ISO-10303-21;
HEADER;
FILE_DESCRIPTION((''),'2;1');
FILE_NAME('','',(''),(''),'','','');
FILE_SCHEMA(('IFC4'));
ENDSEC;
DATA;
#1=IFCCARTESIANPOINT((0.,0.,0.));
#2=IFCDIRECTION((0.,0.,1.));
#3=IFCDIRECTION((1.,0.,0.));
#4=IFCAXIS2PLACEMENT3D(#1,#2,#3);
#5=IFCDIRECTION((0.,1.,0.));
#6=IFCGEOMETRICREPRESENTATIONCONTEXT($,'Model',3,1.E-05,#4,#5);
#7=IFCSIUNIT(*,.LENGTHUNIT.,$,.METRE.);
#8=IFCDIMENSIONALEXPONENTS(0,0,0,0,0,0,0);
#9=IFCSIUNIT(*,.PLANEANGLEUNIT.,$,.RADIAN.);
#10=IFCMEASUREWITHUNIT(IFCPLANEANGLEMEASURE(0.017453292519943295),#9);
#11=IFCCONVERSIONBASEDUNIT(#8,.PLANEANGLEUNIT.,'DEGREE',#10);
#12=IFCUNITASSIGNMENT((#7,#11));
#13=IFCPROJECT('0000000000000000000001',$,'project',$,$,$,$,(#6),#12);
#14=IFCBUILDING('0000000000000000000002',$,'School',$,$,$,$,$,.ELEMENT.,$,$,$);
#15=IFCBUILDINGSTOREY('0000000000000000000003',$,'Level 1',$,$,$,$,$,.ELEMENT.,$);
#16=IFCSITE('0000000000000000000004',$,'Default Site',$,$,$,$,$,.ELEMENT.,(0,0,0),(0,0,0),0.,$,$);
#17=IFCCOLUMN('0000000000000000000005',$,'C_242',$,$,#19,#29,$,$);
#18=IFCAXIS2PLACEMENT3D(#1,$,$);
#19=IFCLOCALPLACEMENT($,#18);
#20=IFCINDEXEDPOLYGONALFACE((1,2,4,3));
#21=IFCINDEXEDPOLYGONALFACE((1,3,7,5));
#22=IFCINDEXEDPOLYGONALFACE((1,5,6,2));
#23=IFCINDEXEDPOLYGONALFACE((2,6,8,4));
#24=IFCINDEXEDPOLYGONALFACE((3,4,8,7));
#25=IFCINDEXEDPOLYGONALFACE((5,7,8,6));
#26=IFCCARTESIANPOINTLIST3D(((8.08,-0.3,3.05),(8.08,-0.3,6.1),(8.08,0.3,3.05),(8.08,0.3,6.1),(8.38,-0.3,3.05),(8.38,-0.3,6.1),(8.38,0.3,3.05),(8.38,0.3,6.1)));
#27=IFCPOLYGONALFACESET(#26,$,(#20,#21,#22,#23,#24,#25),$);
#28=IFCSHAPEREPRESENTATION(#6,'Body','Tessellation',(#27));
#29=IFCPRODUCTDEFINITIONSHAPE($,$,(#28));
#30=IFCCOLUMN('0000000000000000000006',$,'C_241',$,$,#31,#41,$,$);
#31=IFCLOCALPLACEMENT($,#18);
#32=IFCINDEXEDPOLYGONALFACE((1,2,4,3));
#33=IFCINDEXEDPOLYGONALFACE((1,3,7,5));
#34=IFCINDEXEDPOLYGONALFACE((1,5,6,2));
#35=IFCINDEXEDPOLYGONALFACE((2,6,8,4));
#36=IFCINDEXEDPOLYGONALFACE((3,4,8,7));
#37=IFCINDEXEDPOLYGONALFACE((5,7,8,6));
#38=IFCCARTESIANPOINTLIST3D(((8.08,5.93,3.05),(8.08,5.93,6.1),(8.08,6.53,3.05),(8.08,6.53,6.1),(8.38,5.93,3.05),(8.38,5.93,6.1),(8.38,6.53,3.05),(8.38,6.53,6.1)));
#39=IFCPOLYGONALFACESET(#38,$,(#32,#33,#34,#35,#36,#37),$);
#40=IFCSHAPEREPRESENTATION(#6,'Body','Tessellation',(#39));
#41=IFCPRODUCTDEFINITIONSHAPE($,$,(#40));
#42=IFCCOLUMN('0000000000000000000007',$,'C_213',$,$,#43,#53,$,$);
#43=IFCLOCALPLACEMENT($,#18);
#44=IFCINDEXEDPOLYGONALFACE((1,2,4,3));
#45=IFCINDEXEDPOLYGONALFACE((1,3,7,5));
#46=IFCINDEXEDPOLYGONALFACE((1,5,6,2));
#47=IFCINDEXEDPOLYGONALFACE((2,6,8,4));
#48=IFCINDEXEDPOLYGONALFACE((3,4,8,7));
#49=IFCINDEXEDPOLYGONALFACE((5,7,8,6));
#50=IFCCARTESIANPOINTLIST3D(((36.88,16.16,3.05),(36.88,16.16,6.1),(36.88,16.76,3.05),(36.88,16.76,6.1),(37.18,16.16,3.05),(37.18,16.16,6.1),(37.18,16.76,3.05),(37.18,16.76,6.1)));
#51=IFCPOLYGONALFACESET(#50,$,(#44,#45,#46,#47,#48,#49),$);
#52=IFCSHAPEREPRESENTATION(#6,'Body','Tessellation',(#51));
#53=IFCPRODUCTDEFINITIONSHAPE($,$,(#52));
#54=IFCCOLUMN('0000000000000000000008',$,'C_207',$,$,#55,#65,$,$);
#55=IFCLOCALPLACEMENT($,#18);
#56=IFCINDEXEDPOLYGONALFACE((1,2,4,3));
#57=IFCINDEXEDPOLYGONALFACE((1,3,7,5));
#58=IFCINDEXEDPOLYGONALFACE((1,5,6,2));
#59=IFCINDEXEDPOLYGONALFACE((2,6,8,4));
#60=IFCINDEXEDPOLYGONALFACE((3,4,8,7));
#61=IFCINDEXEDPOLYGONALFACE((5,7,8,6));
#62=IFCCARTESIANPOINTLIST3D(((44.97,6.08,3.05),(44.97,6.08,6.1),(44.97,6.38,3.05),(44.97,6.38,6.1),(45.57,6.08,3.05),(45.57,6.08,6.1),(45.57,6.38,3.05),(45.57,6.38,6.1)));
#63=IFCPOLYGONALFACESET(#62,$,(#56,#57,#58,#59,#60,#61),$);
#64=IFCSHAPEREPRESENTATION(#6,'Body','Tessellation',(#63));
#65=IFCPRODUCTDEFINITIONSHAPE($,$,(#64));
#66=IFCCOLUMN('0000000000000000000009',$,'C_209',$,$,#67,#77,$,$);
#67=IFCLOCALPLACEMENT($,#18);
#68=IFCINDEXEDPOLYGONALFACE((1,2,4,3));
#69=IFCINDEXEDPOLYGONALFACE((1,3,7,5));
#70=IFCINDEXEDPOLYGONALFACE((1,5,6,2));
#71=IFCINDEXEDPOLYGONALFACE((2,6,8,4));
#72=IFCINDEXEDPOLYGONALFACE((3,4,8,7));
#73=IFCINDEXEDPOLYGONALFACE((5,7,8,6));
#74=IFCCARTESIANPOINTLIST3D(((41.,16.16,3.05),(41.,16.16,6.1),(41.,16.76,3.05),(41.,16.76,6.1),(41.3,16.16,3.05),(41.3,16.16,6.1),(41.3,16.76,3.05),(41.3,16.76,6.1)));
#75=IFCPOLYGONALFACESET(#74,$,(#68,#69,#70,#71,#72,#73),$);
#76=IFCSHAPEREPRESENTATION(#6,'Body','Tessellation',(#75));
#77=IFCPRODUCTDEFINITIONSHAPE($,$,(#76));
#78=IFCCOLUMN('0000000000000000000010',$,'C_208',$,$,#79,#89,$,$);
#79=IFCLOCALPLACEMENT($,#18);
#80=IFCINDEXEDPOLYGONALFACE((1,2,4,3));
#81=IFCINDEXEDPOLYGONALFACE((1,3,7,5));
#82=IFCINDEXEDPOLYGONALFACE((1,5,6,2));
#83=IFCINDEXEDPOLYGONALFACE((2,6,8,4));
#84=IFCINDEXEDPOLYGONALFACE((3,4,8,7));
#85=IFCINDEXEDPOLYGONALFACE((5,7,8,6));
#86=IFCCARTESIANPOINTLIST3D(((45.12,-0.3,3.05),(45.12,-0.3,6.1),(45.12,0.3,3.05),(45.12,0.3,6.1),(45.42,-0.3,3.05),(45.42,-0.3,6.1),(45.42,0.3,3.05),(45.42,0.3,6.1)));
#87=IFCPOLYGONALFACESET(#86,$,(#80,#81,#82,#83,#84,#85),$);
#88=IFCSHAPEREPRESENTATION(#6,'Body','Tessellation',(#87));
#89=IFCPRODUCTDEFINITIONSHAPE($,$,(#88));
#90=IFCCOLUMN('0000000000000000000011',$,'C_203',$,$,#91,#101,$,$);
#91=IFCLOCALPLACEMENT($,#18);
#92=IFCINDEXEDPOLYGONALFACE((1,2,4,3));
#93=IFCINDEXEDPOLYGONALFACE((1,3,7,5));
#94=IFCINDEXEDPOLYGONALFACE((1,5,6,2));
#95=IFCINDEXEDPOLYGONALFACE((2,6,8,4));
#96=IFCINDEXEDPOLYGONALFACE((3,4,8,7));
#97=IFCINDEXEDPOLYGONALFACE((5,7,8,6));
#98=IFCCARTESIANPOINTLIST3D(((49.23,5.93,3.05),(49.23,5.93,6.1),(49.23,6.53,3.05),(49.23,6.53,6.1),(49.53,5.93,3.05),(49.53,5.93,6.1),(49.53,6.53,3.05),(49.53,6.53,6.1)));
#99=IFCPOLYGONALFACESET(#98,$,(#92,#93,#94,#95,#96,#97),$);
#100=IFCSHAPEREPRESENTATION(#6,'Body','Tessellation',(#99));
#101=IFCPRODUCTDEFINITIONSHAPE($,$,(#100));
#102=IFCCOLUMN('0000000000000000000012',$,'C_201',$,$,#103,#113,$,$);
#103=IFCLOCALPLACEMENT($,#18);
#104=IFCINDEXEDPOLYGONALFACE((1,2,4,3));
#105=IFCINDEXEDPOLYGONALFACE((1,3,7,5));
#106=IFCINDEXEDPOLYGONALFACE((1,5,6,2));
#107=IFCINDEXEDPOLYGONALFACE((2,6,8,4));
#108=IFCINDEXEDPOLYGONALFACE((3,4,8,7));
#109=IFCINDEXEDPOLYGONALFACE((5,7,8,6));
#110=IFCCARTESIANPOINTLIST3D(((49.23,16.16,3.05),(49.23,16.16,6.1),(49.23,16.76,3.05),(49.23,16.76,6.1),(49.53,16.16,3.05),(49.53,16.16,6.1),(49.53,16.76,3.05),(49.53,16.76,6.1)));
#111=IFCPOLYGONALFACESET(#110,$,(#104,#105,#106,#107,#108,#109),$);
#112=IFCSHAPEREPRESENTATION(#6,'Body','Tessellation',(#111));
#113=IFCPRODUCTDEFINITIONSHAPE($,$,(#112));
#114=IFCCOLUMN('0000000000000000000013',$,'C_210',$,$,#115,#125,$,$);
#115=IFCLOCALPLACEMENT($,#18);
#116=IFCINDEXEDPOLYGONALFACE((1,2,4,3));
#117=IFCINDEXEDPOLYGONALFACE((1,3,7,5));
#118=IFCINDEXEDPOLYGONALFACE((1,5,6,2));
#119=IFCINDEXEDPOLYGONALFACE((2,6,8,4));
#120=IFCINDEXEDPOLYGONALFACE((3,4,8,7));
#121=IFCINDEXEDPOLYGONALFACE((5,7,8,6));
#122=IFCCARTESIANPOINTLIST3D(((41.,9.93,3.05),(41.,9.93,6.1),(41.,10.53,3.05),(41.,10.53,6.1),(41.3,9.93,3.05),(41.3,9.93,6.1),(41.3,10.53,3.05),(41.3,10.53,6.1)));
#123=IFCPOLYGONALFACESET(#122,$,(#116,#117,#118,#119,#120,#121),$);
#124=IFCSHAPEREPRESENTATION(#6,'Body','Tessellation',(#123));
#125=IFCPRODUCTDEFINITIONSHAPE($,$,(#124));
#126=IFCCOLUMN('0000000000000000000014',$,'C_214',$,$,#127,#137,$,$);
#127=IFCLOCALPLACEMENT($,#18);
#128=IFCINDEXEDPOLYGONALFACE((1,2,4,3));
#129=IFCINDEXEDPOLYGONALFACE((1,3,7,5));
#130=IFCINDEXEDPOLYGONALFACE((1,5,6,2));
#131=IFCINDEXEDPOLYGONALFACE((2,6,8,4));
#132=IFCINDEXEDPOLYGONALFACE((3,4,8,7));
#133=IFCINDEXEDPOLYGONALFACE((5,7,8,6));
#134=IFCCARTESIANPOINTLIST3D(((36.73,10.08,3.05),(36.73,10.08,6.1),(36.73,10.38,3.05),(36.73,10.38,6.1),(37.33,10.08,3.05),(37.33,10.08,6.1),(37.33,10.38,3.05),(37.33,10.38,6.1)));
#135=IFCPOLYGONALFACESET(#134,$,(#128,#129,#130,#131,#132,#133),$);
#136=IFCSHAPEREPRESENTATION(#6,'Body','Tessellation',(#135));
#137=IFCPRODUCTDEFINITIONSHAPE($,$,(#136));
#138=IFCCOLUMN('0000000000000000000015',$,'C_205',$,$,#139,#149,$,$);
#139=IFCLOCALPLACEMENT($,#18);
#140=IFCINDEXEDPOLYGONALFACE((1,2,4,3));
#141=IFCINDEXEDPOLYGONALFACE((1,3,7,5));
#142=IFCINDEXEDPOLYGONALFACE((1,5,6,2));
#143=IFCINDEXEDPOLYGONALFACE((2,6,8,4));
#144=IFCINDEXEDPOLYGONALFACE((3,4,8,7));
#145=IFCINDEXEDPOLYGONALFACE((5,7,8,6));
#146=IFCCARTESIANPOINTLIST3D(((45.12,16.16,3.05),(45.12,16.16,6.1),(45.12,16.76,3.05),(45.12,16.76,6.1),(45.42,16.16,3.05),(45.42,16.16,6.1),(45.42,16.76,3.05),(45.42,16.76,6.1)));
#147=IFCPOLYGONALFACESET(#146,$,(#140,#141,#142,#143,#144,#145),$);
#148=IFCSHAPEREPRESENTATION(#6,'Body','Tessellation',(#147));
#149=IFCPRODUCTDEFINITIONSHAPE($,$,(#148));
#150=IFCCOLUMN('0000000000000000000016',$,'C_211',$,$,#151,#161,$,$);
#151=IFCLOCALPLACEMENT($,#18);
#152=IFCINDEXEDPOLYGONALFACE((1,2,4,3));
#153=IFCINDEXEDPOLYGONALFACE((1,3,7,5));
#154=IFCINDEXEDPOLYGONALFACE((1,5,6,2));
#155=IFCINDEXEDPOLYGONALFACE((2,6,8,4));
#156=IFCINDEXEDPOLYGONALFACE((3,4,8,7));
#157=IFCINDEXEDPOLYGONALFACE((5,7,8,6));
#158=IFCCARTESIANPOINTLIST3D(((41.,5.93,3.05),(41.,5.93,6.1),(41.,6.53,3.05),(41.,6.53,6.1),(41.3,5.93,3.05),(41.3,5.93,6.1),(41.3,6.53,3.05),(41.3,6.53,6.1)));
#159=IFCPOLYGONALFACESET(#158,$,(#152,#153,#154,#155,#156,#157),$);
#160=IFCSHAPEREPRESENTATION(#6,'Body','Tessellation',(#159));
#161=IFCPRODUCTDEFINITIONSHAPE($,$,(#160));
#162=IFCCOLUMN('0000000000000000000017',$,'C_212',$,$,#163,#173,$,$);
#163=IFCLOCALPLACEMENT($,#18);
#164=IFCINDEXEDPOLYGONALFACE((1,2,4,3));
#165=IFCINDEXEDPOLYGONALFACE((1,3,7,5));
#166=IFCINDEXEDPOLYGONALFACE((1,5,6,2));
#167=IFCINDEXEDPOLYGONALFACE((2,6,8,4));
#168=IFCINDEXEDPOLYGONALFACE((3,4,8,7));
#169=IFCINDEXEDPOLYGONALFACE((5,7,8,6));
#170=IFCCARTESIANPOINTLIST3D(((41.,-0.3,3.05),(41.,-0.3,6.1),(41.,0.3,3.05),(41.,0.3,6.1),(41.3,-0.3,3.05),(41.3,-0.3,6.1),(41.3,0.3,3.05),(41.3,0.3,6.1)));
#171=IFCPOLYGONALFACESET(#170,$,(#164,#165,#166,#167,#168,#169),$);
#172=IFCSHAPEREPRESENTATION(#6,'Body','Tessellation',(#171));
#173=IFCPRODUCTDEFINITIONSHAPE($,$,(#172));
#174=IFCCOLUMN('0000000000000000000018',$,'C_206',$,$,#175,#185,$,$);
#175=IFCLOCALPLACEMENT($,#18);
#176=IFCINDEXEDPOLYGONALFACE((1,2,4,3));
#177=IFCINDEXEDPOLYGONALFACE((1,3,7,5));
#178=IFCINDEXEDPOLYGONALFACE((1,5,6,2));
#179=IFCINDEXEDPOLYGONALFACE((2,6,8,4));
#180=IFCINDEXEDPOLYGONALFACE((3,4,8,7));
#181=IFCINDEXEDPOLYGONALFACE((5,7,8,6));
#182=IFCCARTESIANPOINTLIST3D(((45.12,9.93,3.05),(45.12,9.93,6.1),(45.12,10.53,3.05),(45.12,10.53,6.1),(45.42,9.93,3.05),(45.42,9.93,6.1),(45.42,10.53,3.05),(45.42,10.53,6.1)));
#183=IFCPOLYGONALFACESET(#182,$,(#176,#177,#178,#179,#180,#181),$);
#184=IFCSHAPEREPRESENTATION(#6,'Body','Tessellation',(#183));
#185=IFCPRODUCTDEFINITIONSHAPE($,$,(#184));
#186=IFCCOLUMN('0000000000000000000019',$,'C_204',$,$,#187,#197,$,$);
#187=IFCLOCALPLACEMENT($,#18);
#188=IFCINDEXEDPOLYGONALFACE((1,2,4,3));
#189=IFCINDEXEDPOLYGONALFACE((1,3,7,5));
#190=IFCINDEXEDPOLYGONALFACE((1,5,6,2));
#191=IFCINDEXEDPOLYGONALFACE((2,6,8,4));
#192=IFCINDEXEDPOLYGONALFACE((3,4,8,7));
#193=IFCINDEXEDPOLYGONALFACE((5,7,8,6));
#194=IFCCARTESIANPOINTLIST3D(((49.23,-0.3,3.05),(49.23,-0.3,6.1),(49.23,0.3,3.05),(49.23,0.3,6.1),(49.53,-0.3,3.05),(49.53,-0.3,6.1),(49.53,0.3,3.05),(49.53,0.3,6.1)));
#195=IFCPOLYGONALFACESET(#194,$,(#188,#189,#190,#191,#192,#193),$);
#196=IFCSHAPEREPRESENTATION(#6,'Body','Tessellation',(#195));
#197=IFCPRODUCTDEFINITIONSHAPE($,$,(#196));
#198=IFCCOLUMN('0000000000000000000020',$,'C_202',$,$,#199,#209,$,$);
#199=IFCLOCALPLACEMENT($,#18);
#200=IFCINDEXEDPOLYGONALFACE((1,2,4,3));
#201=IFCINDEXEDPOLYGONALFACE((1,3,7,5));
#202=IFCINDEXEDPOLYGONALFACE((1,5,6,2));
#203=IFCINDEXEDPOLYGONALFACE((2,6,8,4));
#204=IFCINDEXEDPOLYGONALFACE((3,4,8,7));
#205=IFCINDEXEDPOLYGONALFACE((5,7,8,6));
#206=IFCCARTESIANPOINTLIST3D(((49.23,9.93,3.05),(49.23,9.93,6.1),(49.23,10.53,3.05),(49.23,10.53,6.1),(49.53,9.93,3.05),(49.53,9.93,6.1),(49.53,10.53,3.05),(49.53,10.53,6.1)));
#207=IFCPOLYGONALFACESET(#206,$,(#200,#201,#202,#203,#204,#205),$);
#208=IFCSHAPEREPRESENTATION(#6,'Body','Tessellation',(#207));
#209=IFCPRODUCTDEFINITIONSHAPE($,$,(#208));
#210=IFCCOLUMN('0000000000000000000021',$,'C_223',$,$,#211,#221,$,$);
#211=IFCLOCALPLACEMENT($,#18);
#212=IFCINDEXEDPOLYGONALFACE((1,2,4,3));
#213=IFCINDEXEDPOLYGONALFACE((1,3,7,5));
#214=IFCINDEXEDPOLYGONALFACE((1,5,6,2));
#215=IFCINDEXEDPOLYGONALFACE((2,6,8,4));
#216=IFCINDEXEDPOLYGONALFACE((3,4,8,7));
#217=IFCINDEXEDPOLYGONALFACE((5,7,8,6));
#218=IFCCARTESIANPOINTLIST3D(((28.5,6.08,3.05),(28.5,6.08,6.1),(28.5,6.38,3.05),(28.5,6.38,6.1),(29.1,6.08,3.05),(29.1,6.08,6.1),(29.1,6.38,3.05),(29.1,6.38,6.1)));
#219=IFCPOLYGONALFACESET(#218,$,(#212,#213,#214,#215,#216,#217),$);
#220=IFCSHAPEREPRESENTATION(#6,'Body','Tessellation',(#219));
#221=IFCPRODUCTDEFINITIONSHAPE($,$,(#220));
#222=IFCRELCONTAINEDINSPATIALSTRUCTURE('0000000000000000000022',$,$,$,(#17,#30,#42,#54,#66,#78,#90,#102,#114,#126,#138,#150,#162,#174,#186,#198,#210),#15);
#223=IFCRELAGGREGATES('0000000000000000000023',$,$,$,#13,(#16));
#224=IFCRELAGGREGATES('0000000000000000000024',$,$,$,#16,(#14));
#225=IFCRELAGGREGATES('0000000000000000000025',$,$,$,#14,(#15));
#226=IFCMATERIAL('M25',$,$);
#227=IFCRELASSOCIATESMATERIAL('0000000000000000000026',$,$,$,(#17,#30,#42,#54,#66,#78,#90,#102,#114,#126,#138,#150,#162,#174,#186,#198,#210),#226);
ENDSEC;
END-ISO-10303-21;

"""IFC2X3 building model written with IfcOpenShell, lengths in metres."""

from ifc_helpers import new_model, entity, si_unit, converted_unit, direction, frame, frame_2d, origin_with_axes, place, context, project, spatial, rectangle, extrude, material, element, save


model = new_model("IFC2X3")

# Units and contexts
model_context = context("Model", 3, precision=1e-05, world=origin_with_axes(), true_north=direction((0.0, 1.0, 0.0)))
ifc_project = project(units=[si_unit("LENGTHUNIT", "METRE"), converted_unit("PLANEANGLEUNIT", "DEGREE", entity("IfcPlaneAngleMeasure", 0.017453292519943295), si_unit("PLANEANGLEUNIT", "RADIAN"), dimensions=[0, 0, 0, 0, 0, 0, 0])], contexts=[model_context])

# Site, building, storey
site = spatial("IfcSite", under=ifc_project, Name="Default Site", CompositionType="ELEMENT", RefLatitude=(0, 0, 0), RefLongitude=(0, 0, 0), RefElevation=0.0)
building = spatial("IfcBuilding", under=site, Name="School", CompositionType="ELEMENT")
storey = spatial("IfcBuildingStorey", under=building, Name="Level 1", CompositionType="ELEMENT")

# Columns
ifc_material = material(Name="M25")
placement = place(None, origin_with_axes())
element("IfcColumn", 1, at=placement, inside=storey, material=ifc_material, Name="C_242", context=model_context, shape_type="SweptSolid", body=[
    extrude(rectangle(XDim=0.3, YDim=0.6, at=frame_2d((0.0, 0.0), x_axis=(1.0, 0.0, 0.0))), frame((8.23, 0.0, 3.05), z_axis=(0.0, 0.0, 1.0), x_axis=(1.0, 0.0, 0.0)), (0.0, 0.0, 1.0), 3.05),
])
element("IfcColumn", 2, at=placement, inside=storey, material=ifc_material, Name="C_241", context=model_context, shape_type="SweptSolid", body=[
    extrude(rectangle(XDim=0.3, YDim=0.6, at=frame_2d((0.0, 0.0), x_axis=(1.0, 0.0, 0.0))), frame((8.23, 6.23, 3.05), z_axis=(0.0, 0.0, 1.0), x_axis=(1.0, 0.0, 0.0)), (0.0, 0.0, 1.0), 3.05),
])
element("IfcColumn", 3, at=placement, inside=storey, material=ifc_material, Name="C_213", context=model_context, shape_type="SweptSolid", body=[
    extrude(rectangle(XDim=0.3, YDim=0.6, at=frame_2d((0.0, 0.0), x_axis=(1.0, 0.0, 0.0))), frame((37.03, 16.46, 3.05), z_axis=(0.0, 0.0, 1.0), x_axis=(1.0, 0.0, 0.0)), (0.0, 0.0, 1.0), 3.05),
])
element("IfcColumn", 4, at=placement, inside=storey, material=ifc_material, Name="C_207", context=model_context, shape_type="SweptSolid", body=[
    extrude(rectangle(XDim=0.6, YDim=0.3, at=frame_2d((0.0, 0.0), x_axis=(1.0, 0.0, 0.0))), frame((45.27, 6.23, 3.05), z_axis=(0.0, 0.0, 1.0), x_axis=(1.0, 0.0, 0.0)), (0.0, 0.0, 1.0), 3.05),
])
element("IfcColumn", 5, at=placement, inside=storey, material=ifc_material, Name="C_209", context=model_context, shape_type="SweptSolid", body=[
    extrude(rectangle(XDim=0.3, YDim=0.6, at=frame_2d((0.0, 0.0), x_axis=(1.0, 0.0, 0.0))), frame((41.15, 16.46, 3.05), z_axis=(0.0, 0.0, 1.0), x_axis=(1.0, 0.0, 0.0)), (0.0, 0.0, 1.0), 3.05),
])
element("IfcColumn", 6, at=placement, inside=storey, material=ifc_material, Name="C_208", context=model_context, shape_type="SweptSolid", body=[
    extrude(rectangle(XDim=0.3, YDim=0.6, at=frame_2d((0.0, 0.0), x_axis=(1.0, 0.0, 0.0))), frame((45.27, 0.0, 3.05), z_axis=(0.0, 0.0, 1.0), x_axis=(1.0, 0.0, 0.0)), (0.0, 0.0, 1.0), 3.05),
])
element("IfcColumn", 7, at=placement, inside=storey, material=ifc_material, Name="C_203", context=model_context, shape_type="SweptSolid", body=[
    extrude(rectangle(XDim=0.3, YDim=0.6, at=frame_2d((0.0, 0.0), x_axis=(1.0, 0.0, 0.0))), frame((49.38, 6.23, 3.05), z_axis=(0.0, 0.0, 1.0), x_axis=(1.0, 0.0, 0.0)), (0.0, 0.0, 1.0), 3.05),
])
element("IfcColumn", 8, at=placement, inside=storey, material=ifc_material, Name="C_201", context=model_context, shape_type="SweptSolid", body=[
    extrude(rectangle(XDim=0.3, YDim=0.6, at=frame_2d((0.0, 0.0), x_axis=(1.0, 0.0, 0.0))), frame((49.38, 16.46, 3.05), z_axis=(0.0, 0.0, 1.0), x_axis=(1.0, 0.0, 0.0)), (0.0, 0.0, 1.0), 3.05),
])
element("IfcColumn", 9, at=placement, inside=storey, material=ifc_material, Name="C_210", context=model_context, shape_type="SweptSolid", body=[
    extrude(rectangle(XDim=0.3, YDim=0.6, at=frame_2d((0.0, 0.0), x_axis=(1.0, 0.0, 0.0))), frame((41.15, 10.23, 3.05), z_axis=(0.0, 0.0, 1.0), x_axis=(1.0, 0.0, 0.0)), (0.0, 0.0, 1.0), 3.05),
])
element("IfcColumn", 10, at=placement, inside=storey, material=ifc_material, Name="C_214", context=model_context, shape_type="SweptSolid", body=[
    extrude(rectangle(XDim=0.6, YDim=0.3, at=frame_2d((0.0, 0.0), x_axis=(1.0, 0.0, 0.0))), frame((37.03, 10.23, 3.05), z_axis=(0.0, 0.0, 1.0), x_axis=(1.0, 0.0, 0.0)), (0.0, 0.0, 1.0), 3.05),
])
element("IfcColumn", 11, at=placement, inside=storey, material=ifc_material, Name="C_205", context=model_context, shape_type="SweptSolid", body=[
    extrude(rectangle(XDim=0.3, YDim=0.6, at=frame_2d((0.0, 0.0), x_axis=(1.0, 0.0, 0.0))), frame((45.27, 16.46, 3.05), z_axis=(0.0, 0.0, 1.0), x_axis=(1.0, 0.0, 0.0)), (0.0, 0.0, 1.0), 3.05),
])
element("IfcColumn", 12, at=placement, inside=storey, material=ifc_material, Name="C_211", context=model_context, shape_type="SweptSolid", body=[
    extrude(rectangle(XDim=0.3, YDim=0.6, at=frame_2d((0.0, 0.0), x_axis=(1.0, 0.0, 0.0))), frame((41.15, 6.23, 3.05), z_axis=(0.0, 0.0, 1.0), x_axis=(1.0, 0.0, 0.0)), (0.0, 0.0, 1.0), 3.05),
])
element("IfcColumn", 13, at=placement, inside=storey, material=ifc_material, Name="C_212", context=model_context, shape_type="SweptSolid", body=[
    extrude(rectangle(XDim=0.3, YDim=0.6, at=frame_2d((0.0, 0.0), x_axis=(1.0, 0.0, 0.0))), frame((41.15, 0.0, 3.05), z_axis=(0.0, 0.0, 1.0), x_axis=(1.0, 0.0, 0.0)), (0.0, 0.0, 1.0), 3.05),
])
element("IfcColumn", 14, at=placement, inside=storey, material=ifc_material, Name="C_206", context=model_context, shape_type="SweptSolid", body=[
    extrude(rectangle(XDim=0.3, YDim=0.6, at=frame_2d((0.0, 0.0), x_axis=(1.0, 0.0, 0.0))), frame((45.27, 10.23, 3.05), z_axis=(0.0, 0.0, 1.0), x_axis=(1.0, 0.0, 0.0)), (0.0, 0.0, 1.0), 3.05),
])
element("IfcColumn", 15, at=placement, inside=storey, material=ifc_material, Name="C_204", context=model_context, shape_type="SweptSolid", body=[
    extrude(rectangle(XDim=0.3, YDim=0.6, at=frame_2d((0.0, 0.0), x_axis=(1.0, 0.0, 0.0))), frame((49.38, 0.0, 3.05), z_axis=(0.0, 0.0, 1.0), x_axis=(1.0, 0.0, 0.0)), (0.0, 0.0, 1.0), 3.05),
])
element("IfcColumn", 16, at=placement, inside=storey, material=ifc_material, Name="C_202", context=model_context, shape_type="SweptSolid", body=[
    extrude(rectangle(XDim=0.3, YDim=0.6, at=frame_2d((0.0, 0.0), x_axis=(1.0, 0.0, 0.0))), frame((49.38, 10.23, 3.05), z_axis=(0.0, 0.0, 1.0), x_axis=(1.0, 0.0, 0.0)), (0.0, 0.0, 1.0), 3.05),
])
element("IfcColumn", 17, at=placement, inside=storey, material=ifc_material, Name="C_223", context=model_context, shape_type="SweptSolid", body=[
    extrude(rectangle(XDim=0.6, YDim=0.3, at=frame_2d((0.0, 0.0), x_axis=(1.0, 0.0, 0.0))), frame((28.8, 6.23, 3.05), z_axis=(0.0, 0.0, 1.0), x_axis=(1.0, 0.0, 0.0)), (0.0, 0.0, 1.0), 3.05),
])

save(model, "model.ifc")
